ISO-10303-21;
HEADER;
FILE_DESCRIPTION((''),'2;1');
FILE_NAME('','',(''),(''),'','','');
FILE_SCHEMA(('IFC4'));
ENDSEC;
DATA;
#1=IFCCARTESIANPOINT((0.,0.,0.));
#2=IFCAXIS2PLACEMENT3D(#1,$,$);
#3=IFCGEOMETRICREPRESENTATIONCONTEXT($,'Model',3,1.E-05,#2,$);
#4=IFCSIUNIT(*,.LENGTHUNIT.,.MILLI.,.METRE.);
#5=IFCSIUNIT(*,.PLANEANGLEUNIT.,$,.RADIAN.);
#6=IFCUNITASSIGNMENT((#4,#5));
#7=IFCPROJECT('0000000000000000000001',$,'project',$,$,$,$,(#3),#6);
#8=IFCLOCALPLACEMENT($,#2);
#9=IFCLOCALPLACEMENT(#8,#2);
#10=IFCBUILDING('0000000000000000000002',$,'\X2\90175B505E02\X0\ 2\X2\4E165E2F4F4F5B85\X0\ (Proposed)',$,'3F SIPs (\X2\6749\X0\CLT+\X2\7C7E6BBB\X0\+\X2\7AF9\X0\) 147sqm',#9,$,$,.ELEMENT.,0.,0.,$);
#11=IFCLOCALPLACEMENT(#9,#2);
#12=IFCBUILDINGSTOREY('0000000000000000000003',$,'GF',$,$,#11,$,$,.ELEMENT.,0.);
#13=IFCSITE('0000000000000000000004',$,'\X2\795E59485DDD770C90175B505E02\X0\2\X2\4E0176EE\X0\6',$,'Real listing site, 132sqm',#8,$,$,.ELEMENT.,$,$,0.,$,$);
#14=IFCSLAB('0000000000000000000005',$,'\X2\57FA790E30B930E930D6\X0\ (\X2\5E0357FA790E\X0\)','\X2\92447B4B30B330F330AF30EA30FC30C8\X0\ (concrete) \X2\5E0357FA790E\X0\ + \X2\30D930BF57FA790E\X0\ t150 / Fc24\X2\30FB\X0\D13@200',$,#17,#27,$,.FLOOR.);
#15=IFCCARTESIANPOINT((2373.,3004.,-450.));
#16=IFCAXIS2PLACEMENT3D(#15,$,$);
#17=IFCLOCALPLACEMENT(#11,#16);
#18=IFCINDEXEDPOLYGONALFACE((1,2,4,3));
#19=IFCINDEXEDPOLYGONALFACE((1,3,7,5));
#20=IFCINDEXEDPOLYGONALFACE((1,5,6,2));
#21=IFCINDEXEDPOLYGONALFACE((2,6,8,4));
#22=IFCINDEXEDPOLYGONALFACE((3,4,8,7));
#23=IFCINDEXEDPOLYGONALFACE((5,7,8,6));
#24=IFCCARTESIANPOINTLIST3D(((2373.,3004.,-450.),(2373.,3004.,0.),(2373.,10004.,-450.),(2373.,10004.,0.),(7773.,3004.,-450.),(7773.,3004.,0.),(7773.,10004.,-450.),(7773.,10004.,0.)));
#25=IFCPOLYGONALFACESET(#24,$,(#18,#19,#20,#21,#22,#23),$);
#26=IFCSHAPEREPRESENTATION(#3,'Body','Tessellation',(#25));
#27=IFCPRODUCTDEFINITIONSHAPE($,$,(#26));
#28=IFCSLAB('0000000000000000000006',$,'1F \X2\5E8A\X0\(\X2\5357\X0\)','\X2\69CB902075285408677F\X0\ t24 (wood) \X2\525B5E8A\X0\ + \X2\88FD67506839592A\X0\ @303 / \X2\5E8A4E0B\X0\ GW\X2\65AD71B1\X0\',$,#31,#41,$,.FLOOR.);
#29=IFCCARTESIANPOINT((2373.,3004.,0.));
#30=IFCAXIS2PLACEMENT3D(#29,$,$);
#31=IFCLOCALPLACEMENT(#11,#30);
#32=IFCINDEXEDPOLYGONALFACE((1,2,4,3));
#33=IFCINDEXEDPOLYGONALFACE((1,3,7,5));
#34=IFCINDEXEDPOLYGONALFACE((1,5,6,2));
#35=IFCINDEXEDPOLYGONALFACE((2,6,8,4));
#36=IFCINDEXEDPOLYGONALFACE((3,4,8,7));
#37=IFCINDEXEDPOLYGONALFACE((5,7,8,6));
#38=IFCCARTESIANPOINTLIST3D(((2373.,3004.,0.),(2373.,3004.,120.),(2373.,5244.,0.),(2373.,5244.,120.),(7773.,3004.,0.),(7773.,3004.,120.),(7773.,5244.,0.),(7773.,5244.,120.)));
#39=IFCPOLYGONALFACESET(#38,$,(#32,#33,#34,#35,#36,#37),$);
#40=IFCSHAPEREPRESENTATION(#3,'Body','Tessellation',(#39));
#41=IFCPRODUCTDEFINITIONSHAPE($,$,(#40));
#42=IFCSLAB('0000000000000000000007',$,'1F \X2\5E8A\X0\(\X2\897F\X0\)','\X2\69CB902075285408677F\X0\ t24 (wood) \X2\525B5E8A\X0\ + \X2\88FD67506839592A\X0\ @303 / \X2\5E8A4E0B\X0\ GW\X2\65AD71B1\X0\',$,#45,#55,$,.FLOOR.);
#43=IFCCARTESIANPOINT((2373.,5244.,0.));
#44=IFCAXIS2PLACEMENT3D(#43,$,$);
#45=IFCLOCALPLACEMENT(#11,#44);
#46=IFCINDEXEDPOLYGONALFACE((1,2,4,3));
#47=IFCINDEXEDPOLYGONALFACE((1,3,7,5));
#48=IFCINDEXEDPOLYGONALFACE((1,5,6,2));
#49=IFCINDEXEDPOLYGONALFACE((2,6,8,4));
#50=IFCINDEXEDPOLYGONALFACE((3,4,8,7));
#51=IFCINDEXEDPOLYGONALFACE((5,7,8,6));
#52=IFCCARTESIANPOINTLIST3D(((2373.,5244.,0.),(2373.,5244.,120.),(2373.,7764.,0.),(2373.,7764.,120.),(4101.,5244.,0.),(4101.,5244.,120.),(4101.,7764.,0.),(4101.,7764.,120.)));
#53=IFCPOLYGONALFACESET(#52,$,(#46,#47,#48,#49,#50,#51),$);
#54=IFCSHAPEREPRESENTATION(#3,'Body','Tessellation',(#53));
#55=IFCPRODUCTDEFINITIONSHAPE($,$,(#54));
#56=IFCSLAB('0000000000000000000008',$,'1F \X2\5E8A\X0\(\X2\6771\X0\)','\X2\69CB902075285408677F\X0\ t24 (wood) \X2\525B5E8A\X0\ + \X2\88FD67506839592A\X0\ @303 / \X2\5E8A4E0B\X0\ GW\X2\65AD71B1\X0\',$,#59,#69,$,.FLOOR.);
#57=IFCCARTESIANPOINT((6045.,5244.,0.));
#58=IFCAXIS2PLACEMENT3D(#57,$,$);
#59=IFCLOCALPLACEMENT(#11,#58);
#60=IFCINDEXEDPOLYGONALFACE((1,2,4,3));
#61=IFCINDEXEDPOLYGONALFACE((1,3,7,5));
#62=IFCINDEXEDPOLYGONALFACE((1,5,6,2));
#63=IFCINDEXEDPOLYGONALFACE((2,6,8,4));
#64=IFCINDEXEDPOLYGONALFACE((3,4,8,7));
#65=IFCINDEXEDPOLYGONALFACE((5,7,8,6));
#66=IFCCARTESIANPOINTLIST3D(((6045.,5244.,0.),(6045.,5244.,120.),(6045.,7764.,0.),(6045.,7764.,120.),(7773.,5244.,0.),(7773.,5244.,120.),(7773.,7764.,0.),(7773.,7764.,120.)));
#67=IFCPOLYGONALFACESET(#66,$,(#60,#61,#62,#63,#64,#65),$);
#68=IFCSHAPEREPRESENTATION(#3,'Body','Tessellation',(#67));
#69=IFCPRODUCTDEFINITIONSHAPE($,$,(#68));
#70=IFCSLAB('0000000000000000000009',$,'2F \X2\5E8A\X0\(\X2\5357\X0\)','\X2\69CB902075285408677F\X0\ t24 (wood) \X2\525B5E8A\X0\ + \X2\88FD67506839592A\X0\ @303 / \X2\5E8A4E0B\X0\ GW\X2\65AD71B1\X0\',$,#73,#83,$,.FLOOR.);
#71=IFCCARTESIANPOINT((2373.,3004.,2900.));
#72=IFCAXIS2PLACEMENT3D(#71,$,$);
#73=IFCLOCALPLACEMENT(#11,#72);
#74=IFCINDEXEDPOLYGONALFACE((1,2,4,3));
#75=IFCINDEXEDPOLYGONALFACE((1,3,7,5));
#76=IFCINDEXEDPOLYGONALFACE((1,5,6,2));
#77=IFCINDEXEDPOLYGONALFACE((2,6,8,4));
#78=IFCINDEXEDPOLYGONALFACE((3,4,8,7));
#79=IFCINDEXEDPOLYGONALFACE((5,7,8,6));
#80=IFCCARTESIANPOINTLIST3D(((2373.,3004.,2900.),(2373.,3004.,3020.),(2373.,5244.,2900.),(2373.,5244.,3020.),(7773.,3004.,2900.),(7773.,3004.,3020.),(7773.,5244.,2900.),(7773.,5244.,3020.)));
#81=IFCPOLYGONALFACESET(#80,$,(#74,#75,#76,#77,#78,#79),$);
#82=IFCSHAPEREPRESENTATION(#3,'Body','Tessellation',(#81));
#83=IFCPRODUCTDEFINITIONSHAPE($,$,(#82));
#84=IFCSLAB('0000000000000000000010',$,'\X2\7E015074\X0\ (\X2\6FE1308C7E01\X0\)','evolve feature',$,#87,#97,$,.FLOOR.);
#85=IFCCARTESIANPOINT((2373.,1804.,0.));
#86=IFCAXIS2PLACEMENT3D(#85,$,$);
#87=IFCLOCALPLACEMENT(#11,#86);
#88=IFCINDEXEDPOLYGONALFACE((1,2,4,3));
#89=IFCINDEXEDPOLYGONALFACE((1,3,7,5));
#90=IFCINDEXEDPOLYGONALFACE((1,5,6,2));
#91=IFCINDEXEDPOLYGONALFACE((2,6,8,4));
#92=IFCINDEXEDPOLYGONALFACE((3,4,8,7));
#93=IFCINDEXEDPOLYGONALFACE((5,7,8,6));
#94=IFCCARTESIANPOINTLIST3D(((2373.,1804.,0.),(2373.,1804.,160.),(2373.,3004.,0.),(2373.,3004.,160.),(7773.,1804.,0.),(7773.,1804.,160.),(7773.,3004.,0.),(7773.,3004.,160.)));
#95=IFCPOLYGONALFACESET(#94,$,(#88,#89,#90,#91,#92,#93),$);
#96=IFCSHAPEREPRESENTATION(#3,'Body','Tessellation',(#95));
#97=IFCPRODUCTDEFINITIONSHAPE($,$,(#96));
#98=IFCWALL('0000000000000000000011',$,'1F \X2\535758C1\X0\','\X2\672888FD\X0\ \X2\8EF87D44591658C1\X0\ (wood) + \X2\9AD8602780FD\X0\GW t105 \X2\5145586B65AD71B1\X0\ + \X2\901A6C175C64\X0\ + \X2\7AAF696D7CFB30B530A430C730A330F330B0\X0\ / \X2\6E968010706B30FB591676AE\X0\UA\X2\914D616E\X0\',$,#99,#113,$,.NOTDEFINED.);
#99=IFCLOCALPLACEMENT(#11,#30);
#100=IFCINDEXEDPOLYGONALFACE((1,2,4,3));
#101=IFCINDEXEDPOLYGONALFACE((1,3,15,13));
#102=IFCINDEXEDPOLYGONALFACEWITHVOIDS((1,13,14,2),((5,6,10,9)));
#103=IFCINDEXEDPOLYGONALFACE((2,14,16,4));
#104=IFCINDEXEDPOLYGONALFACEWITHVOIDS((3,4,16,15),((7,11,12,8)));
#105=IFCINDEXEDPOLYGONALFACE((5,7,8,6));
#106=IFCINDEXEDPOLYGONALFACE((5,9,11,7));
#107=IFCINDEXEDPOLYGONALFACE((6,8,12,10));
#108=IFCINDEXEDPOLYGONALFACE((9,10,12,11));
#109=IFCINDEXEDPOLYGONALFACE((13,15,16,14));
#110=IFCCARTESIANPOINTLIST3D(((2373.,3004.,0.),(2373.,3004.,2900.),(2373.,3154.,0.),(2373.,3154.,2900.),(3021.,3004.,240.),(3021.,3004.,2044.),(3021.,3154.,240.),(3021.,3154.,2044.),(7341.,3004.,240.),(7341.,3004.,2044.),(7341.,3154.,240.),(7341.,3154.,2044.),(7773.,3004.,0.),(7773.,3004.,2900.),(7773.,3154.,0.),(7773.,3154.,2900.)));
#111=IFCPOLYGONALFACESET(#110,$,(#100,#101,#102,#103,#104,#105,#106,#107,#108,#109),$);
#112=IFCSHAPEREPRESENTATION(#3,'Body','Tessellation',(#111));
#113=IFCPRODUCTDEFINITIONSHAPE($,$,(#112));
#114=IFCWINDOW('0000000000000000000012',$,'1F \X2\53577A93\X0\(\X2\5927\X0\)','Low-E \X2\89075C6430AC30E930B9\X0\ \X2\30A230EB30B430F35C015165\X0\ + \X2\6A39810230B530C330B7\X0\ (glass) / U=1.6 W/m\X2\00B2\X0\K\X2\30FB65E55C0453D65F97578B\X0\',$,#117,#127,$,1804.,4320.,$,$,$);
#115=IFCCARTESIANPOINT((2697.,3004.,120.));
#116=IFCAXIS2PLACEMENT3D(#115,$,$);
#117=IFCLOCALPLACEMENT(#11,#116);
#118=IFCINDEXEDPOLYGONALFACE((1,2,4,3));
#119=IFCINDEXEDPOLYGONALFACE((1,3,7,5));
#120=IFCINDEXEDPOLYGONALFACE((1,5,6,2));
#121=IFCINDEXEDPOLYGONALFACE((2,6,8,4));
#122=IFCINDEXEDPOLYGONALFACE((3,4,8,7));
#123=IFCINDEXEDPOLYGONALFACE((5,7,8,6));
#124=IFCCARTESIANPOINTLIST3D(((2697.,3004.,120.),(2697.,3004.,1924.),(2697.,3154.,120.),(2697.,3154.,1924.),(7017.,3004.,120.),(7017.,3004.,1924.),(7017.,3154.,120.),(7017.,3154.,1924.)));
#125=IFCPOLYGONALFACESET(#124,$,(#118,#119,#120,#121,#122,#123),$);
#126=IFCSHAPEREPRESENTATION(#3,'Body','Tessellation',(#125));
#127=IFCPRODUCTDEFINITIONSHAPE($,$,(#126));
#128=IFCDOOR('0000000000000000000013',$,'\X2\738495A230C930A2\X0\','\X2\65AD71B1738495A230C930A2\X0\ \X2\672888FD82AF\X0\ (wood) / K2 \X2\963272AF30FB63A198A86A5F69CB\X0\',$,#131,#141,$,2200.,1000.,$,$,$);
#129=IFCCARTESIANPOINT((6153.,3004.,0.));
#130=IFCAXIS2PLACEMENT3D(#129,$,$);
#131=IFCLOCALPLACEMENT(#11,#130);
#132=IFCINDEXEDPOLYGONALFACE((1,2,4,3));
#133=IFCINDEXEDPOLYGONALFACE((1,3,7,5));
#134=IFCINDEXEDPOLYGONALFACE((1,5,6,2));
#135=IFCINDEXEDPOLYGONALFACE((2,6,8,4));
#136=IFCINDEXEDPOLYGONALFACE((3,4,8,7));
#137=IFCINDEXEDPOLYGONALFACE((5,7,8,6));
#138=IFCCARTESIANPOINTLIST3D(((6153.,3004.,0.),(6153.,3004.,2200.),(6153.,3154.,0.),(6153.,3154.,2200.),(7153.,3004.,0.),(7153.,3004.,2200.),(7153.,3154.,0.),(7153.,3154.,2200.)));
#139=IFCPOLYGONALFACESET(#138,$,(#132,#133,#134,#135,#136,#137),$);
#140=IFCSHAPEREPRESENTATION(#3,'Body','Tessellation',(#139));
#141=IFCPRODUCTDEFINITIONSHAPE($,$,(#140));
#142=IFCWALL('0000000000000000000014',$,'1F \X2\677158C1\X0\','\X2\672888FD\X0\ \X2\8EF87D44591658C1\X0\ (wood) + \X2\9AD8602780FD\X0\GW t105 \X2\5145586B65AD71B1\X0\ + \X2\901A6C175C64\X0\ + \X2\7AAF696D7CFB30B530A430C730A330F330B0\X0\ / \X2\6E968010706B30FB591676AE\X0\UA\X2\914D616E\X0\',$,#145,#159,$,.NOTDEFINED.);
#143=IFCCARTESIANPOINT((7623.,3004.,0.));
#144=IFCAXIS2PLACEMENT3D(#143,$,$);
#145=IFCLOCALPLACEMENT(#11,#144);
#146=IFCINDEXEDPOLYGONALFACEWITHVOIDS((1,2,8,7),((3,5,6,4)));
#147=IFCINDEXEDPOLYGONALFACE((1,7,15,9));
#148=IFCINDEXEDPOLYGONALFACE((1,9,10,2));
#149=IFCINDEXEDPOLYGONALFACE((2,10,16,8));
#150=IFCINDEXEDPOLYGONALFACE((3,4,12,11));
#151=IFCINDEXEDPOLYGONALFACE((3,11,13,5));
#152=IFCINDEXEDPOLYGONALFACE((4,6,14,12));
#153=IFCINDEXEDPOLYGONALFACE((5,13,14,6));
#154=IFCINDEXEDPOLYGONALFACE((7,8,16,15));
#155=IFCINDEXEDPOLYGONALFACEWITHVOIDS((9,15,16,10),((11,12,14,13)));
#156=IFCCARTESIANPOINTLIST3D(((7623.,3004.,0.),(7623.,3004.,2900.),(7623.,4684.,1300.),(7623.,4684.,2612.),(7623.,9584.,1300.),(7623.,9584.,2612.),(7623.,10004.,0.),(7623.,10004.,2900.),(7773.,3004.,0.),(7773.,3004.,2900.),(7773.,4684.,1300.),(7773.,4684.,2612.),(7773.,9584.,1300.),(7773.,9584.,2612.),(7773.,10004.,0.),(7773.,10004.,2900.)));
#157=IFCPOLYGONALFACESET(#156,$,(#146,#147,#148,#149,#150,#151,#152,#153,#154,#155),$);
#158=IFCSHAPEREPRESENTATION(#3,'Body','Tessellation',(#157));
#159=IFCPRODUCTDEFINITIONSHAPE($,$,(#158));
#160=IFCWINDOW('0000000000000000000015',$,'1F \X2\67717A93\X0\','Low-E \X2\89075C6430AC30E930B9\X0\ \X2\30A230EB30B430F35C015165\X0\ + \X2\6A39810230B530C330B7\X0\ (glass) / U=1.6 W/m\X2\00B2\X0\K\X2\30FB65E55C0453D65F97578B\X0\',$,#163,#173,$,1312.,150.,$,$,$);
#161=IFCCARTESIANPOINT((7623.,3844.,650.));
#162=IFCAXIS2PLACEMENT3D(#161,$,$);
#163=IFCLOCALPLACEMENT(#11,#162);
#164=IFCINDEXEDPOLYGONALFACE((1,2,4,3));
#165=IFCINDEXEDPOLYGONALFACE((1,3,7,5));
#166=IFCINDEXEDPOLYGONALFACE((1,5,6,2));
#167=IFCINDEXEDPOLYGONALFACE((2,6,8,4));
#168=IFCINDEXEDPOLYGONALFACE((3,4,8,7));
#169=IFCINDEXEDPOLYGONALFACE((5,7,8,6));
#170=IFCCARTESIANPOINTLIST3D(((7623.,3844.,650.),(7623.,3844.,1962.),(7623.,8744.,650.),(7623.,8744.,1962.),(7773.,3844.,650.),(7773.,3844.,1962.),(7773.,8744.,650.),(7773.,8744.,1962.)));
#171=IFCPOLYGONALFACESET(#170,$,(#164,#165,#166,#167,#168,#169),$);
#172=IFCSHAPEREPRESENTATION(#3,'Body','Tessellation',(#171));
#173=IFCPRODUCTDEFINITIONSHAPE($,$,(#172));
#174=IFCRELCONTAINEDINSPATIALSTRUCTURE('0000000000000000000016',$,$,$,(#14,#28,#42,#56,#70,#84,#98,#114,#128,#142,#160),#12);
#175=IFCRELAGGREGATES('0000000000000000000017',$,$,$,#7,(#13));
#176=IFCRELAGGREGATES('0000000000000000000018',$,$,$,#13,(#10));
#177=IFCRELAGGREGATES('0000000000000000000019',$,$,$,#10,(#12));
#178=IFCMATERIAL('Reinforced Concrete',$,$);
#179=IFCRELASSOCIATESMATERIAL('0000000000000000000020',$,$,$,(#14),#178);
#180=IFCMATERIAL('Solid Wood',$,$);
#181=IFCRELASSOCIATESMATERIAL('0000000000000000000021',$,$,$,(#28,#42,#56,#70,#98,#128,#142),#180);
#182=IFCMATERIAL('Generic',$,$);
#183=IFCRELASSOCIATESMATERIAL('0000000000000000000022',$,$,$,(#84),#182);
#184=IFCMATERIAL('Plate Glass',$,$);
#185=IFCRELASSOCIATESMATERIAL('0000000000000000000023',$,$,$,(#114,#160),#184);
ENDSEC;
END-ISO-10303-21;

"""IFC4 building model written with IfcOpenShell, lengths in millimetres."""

from ifc_helpers import new_model, si_unit, frame, frame_2d, origin, place, context, project, spatial, rectangle, extrude, material, element, fill, save


model = new_model("IFC4")

# Units and contexts
model_context = context("Model", 3, precision=1e-05, world=origin())
ifc_project = project(units=[si_unit("LENGTHUNIT", "METRE", prefix="MILLI"), si_unit("PLANEANGLEUNIT", "RADIAN")], contexts=[model_context])

# Site, building, storey
site_placement = place(None, origin())
site = spatial("IfcSite", under=ifc_project, at=site_placement, Name="神奈川県逗子市2丁目6", ObjectType="Real listing site, 132sqm", CompositionType="ELEMENT", RefElevation=0.0)
building_placement = place(site_placement, origin())
building = spatial("IfcBuilding", under=site, at=building_placement, Name="逗子市 2世帯住宅 (Proposed)", ObjectType="3F SIPs (杉CLT+籾殻+竹) 147sqm", CompositionType="ELEMENT", ElevationOfRefHeight=0.0, ElevationOfTerrain=0.0)
storey_placement = place(building_placement, origin())
storey = spatial("IfcBuildingStorey", under=building, at=storey_placement, Name="GF", CompositionType="ELEMENT", Elevation=0.0)

# Slabs
ifc_material_1 = material(Name="Reinforced Concrete")
slab_1_placement = place(storey_placement, frame((2373.0, 3004.0, -450.0)))
element("IfcSlab", 1, at=slab_1_placement, inside=storey, material=ifc_material_1, Name="基礎スラブ (布基礎)", Description="鉄筋コンクリート (concrete) 布基礎 + ベタ基礎 t150 / Fc24・D13@200", PredefinedType="FLOOR", context=model_context, shape_type="SweptSolid", body=[
    extrude(rectangle(XDim=5400.0, YDim=7000.0, at=frame_2d((2700.0, 3500.0))), frame((2373.0, 3004.0, -450.0)), (0.0, 0.0, 1.0), 450.0),
])
ifc_material_2 = material(Name="Solid Wood")
slab_2_placement = place(storey_placement, frame((2373.0, 3004.0, 0.0)))
element("IfcSlab", 2, at=slab_2_placement, inside=storey, material=ifc_material_2, Name="1F 床(南)", Description="構造用合板 t24 (wood) 剛床 + 製材根太 @303 / 床下 GW断熱", PredefinedType="FLOOR", context=model_context, shape_type="SweptSolid", body=[
    extrude(rectangle(XDim=5400.0, YDim=2240.0, at=frame_2d((2700.0, 1120.0))), frame((2373.0, 3004.0, 0.0)), (0.0, 0.0, 1.0), 120.0),
])
slab_3_placement = place(storey_placement, frame((2373.0, 5244.0, 0.0)))
element("IfcSlab", 3, at=slab_3_placement, inside=storey, material=ifc_material_2, Name="1F 床(西)", Description="構造用合板 t24 (wood) 剛床 + 製材根太 @303 / 床下 GW断熱", PredefinedType="FLOOR", context=model_context, shape_type="SweptSolid", body=[
    extrude(rectangle(XDim=1728.0, YDim=2520.0, at=frame_2d((864.0, 1260.0))), frame((2373.0, 5244.0, 0.0)), (0.0, 0.0, 1.0), 120.0),
])
slab_4_placement = place(storey_placement, frame((6045.0, 5244.0, 0.0)))
element("IfcSlab", 4, at=slab_4_placement, inside=storey, material=ifc_material_2, Name="1F 床(東)", Description="構造用合板 t24 (wood) 剛床 + 製材根太 @303 / 床下 GW断熱", PredefinedType="FLOOR", context=model_context, shape_type="SweptSolid", body=[
    extrude(rectangle(XDim=1728.0, YDim=2520.0, at=frame_2d((864.0, 1260.0))), frame((6045.0, 5244.0, 0.0)), (0.0, 0.0, 1.0), 120.0),
])
slab_5_placement = place(storey_placement, frame((2373.0, 3004.0, 2900.0)))
element("IfcSlab", 5, at=slab_5_placement, inside=storey, material=ifc_material_2, Name="2F 床(南)", Description="構造用合板 t24 (wood) 剛床 + 製材根太 @303 / 床下 GW断熱", PredefinedType="FLOOR", context=model_context, shape_type="SweptSolid", body=[
    extrude(rectangle(XDim=5400.0, YDim=2240.0, at=frame_2d((2700.0, 1120.0))), frame((2373.0, 3004.0, 2900.0)), (0.0, 0.0, 1.0), 120.0),
])
ifc_material_3 = material(Name="Generic")
slab_6_placement = place(storey_placement, frame((2373.0, 1804.0, 0.0)))
element("IfcSlab", 6, at=slab_6_placement, inside=storey, material=ifc_material_3, Name="縁側 (濡れ縁)", Description="evolve feature", PredefinedType="FLOOR", context=model_context, shape_type="SweptSolid", body=[
    extrude(rectangle(XDim=5400.0, YDim=1200.0, at=frame_2d((2700.0, 600.0))), frame((2373.0, 1804.0, 0.0)), (0.0, 0.0, 1.0), 160.0),
])

# Wall, openings, window, door
wall_1_placement = place(storey_placement, frame((2373.0, 3004.0, 0.0)))
wall_1 = element("IfcWall", 7, at=wall_1_placement, inside=storey, material=ifc_material_2, Name="1F 南壁", Description="木製 軸組外壁 (wood) + 高性能GW t105 充填断熱 + 通気層 + 窯業系サイディング / 準耐火・外皮UA配慮", PredefinedType="NOTDEFINED", context=model_context, shape_type="SweptSolid", body=[
    extrude(rectangle(XDim=5400.0, YDim=150.0, at=frame_2d((2700.0, 75.0))), frame((2373.0, 3004.0, 0.0)), (0.0, 0.0, 1.0), 2900.0),
])
opening_1_placement = place(storey_placement, frame((2697.0, 3004.0, 120.0)))
opening_1 = element("IfcOpeningElement", 8, at=opening_1_placement, cuts=wall_1, PredefinedType="NOTDEFINED", context=model_context, shape_type="SweptSolid", body=[
    extrude(rectangle(XDim=4320.0, YDim=150.0, at=frame_2d((2160.0, 75.0))), frame((2697.0, 3004.0, 120.0)), (0.0, 0.0, 1.0), 1804.0),
])
opening_2_placement = place(storey_placement, frame((6153.0, 3004.0, 0.0)))
opening_2 = element("IfcOpeningElement", 9, at=opening_2_placement, cuts=wall_1, PredefinedType="NOTDEFINED", context=model_context, shape_type="SweptSolid", body=[
    extrude(rectangle(XDim=1000.0, YDim=150.0, at=frame_2d((500.0, 75.0))), frame((6153.0, 3004.0, 0.0)), (0.0, 0.0, 1.0), 2200.0),
])
ifc_material_4 = material(Name="Plate Glass")
window_1_placement = place(storey_placement, frame((2697.0, 3004.0, 120.0)))
window_1 = element("IfcWindow", 10, at=window_1_placement, inside=storey, material=ifc_material_4, Name="1F 南窓(大)", Description="Low-E 複層ガラス アルゴン封入 + 樹脂サッシ (glass) / U=1.6 W/m²K・日射取得型", OverallHeight=1804.0, OverallWidth=4320.0, context=model_context, shape_type="SweptSolid", body=[
    extrude(rectangle(XDim=4320.0, YDim=150.0, at=frame_2d((2160.0, 75.0))), frame((2697.0, 3004.0, 120.0)), (0.0, 0.0, 1.0), 1804.0),
])
fill(opening_1, window_1)
door_placement = place(storey_placement, frame((6153.0, 3004.0, 0.0)))
door = element("IfcDoor", 11, at=door_placement, inside=storey, material=ifc_material_2, Name="玄関ドア", Description="断熱玄関ドア 木製芯 (wood) / K2 防犯・採風機構", OverallHeight=2200.0, OverallWidth=1000.0, context=model_context, shape_type="SweptSolid", body=[
    extrude(rectangle(XDim=1000.0, YDim=150.0, at=frame_2d((500.0, 75.0))), frame((6153.0, 3004.0, 0.0)), (0.0, 0.0, 1.0), 2200.0),
])
fill(opening_2, door)

# Wall, opening, window
wall_2_placement = place(storey_placement, frame((7623.0, 3004.0, 0.0)))
wall_2 = element("IfcWall", 12, at=wall_2_placement, inside=storey, material=ifc_material_2, Name="1F 東壁", Description="木製 軸組外壁 (wood) + 高性能GW t105 充填断熱 + 通気層 + 窯業系サイディング / 準耐火・外皮UA配慮", PredefinedType="NOTDEFINED", context=model_context, shape_type="SweptSolid", body=[
    extrude(rectangle(XDim=150.0, YDim=7000.0, at=frame_2d((75.0, 3500.0))), frame((7623.0, 3004.0, 0.0)), (0.0, 0.0, 1.0), 2900.0),
])
opening_3_placement = place(storey_placement, frame((7623.0, 3844.0, 650.0)))
opening_3 = element("IfcOpeningElement", 13, at=opening_3_placement, cuts=wall_2, PredefinedType="NOTDEFINED", context=model_context, shape_type="SweptSolid", body=[
    extrude(rectangle(XDim=150.0, YDim=4900.0, at=frame_2d((75.0, 2450.0))), frame((7623.0, 3844.0, 650.0)), (0.0, 0.0, 1.0), 1312.0),
])
window_2_placement = place(storey_placement, frame((7623.0, 3844.0, 650.0)))
window_2 = element("IfcWindow", 14, at=window_2_placement, inside=storey, material=ifc_material_4, Name="1F 東窓", Description="Low-E 複層ガラス アルゴン封入 + 樹脂サッシ (glass) / U=1.6 W/m²K・日射取得型", OverallHeight=1312.0, OverallWidth=150.0, context=model_context, shape_type="SweptSolid", body=[
    extrude(rectangle(XDim=150.0, YDim=4900.0, at=frame_2d((75.0, 2450.0))), frame((7623.0, 3844.0, 650.0)), (0.0, 0.0, 1.0), 1312.0),
])
fill(opening_3, window_2)

save(model, "model.ifc")
